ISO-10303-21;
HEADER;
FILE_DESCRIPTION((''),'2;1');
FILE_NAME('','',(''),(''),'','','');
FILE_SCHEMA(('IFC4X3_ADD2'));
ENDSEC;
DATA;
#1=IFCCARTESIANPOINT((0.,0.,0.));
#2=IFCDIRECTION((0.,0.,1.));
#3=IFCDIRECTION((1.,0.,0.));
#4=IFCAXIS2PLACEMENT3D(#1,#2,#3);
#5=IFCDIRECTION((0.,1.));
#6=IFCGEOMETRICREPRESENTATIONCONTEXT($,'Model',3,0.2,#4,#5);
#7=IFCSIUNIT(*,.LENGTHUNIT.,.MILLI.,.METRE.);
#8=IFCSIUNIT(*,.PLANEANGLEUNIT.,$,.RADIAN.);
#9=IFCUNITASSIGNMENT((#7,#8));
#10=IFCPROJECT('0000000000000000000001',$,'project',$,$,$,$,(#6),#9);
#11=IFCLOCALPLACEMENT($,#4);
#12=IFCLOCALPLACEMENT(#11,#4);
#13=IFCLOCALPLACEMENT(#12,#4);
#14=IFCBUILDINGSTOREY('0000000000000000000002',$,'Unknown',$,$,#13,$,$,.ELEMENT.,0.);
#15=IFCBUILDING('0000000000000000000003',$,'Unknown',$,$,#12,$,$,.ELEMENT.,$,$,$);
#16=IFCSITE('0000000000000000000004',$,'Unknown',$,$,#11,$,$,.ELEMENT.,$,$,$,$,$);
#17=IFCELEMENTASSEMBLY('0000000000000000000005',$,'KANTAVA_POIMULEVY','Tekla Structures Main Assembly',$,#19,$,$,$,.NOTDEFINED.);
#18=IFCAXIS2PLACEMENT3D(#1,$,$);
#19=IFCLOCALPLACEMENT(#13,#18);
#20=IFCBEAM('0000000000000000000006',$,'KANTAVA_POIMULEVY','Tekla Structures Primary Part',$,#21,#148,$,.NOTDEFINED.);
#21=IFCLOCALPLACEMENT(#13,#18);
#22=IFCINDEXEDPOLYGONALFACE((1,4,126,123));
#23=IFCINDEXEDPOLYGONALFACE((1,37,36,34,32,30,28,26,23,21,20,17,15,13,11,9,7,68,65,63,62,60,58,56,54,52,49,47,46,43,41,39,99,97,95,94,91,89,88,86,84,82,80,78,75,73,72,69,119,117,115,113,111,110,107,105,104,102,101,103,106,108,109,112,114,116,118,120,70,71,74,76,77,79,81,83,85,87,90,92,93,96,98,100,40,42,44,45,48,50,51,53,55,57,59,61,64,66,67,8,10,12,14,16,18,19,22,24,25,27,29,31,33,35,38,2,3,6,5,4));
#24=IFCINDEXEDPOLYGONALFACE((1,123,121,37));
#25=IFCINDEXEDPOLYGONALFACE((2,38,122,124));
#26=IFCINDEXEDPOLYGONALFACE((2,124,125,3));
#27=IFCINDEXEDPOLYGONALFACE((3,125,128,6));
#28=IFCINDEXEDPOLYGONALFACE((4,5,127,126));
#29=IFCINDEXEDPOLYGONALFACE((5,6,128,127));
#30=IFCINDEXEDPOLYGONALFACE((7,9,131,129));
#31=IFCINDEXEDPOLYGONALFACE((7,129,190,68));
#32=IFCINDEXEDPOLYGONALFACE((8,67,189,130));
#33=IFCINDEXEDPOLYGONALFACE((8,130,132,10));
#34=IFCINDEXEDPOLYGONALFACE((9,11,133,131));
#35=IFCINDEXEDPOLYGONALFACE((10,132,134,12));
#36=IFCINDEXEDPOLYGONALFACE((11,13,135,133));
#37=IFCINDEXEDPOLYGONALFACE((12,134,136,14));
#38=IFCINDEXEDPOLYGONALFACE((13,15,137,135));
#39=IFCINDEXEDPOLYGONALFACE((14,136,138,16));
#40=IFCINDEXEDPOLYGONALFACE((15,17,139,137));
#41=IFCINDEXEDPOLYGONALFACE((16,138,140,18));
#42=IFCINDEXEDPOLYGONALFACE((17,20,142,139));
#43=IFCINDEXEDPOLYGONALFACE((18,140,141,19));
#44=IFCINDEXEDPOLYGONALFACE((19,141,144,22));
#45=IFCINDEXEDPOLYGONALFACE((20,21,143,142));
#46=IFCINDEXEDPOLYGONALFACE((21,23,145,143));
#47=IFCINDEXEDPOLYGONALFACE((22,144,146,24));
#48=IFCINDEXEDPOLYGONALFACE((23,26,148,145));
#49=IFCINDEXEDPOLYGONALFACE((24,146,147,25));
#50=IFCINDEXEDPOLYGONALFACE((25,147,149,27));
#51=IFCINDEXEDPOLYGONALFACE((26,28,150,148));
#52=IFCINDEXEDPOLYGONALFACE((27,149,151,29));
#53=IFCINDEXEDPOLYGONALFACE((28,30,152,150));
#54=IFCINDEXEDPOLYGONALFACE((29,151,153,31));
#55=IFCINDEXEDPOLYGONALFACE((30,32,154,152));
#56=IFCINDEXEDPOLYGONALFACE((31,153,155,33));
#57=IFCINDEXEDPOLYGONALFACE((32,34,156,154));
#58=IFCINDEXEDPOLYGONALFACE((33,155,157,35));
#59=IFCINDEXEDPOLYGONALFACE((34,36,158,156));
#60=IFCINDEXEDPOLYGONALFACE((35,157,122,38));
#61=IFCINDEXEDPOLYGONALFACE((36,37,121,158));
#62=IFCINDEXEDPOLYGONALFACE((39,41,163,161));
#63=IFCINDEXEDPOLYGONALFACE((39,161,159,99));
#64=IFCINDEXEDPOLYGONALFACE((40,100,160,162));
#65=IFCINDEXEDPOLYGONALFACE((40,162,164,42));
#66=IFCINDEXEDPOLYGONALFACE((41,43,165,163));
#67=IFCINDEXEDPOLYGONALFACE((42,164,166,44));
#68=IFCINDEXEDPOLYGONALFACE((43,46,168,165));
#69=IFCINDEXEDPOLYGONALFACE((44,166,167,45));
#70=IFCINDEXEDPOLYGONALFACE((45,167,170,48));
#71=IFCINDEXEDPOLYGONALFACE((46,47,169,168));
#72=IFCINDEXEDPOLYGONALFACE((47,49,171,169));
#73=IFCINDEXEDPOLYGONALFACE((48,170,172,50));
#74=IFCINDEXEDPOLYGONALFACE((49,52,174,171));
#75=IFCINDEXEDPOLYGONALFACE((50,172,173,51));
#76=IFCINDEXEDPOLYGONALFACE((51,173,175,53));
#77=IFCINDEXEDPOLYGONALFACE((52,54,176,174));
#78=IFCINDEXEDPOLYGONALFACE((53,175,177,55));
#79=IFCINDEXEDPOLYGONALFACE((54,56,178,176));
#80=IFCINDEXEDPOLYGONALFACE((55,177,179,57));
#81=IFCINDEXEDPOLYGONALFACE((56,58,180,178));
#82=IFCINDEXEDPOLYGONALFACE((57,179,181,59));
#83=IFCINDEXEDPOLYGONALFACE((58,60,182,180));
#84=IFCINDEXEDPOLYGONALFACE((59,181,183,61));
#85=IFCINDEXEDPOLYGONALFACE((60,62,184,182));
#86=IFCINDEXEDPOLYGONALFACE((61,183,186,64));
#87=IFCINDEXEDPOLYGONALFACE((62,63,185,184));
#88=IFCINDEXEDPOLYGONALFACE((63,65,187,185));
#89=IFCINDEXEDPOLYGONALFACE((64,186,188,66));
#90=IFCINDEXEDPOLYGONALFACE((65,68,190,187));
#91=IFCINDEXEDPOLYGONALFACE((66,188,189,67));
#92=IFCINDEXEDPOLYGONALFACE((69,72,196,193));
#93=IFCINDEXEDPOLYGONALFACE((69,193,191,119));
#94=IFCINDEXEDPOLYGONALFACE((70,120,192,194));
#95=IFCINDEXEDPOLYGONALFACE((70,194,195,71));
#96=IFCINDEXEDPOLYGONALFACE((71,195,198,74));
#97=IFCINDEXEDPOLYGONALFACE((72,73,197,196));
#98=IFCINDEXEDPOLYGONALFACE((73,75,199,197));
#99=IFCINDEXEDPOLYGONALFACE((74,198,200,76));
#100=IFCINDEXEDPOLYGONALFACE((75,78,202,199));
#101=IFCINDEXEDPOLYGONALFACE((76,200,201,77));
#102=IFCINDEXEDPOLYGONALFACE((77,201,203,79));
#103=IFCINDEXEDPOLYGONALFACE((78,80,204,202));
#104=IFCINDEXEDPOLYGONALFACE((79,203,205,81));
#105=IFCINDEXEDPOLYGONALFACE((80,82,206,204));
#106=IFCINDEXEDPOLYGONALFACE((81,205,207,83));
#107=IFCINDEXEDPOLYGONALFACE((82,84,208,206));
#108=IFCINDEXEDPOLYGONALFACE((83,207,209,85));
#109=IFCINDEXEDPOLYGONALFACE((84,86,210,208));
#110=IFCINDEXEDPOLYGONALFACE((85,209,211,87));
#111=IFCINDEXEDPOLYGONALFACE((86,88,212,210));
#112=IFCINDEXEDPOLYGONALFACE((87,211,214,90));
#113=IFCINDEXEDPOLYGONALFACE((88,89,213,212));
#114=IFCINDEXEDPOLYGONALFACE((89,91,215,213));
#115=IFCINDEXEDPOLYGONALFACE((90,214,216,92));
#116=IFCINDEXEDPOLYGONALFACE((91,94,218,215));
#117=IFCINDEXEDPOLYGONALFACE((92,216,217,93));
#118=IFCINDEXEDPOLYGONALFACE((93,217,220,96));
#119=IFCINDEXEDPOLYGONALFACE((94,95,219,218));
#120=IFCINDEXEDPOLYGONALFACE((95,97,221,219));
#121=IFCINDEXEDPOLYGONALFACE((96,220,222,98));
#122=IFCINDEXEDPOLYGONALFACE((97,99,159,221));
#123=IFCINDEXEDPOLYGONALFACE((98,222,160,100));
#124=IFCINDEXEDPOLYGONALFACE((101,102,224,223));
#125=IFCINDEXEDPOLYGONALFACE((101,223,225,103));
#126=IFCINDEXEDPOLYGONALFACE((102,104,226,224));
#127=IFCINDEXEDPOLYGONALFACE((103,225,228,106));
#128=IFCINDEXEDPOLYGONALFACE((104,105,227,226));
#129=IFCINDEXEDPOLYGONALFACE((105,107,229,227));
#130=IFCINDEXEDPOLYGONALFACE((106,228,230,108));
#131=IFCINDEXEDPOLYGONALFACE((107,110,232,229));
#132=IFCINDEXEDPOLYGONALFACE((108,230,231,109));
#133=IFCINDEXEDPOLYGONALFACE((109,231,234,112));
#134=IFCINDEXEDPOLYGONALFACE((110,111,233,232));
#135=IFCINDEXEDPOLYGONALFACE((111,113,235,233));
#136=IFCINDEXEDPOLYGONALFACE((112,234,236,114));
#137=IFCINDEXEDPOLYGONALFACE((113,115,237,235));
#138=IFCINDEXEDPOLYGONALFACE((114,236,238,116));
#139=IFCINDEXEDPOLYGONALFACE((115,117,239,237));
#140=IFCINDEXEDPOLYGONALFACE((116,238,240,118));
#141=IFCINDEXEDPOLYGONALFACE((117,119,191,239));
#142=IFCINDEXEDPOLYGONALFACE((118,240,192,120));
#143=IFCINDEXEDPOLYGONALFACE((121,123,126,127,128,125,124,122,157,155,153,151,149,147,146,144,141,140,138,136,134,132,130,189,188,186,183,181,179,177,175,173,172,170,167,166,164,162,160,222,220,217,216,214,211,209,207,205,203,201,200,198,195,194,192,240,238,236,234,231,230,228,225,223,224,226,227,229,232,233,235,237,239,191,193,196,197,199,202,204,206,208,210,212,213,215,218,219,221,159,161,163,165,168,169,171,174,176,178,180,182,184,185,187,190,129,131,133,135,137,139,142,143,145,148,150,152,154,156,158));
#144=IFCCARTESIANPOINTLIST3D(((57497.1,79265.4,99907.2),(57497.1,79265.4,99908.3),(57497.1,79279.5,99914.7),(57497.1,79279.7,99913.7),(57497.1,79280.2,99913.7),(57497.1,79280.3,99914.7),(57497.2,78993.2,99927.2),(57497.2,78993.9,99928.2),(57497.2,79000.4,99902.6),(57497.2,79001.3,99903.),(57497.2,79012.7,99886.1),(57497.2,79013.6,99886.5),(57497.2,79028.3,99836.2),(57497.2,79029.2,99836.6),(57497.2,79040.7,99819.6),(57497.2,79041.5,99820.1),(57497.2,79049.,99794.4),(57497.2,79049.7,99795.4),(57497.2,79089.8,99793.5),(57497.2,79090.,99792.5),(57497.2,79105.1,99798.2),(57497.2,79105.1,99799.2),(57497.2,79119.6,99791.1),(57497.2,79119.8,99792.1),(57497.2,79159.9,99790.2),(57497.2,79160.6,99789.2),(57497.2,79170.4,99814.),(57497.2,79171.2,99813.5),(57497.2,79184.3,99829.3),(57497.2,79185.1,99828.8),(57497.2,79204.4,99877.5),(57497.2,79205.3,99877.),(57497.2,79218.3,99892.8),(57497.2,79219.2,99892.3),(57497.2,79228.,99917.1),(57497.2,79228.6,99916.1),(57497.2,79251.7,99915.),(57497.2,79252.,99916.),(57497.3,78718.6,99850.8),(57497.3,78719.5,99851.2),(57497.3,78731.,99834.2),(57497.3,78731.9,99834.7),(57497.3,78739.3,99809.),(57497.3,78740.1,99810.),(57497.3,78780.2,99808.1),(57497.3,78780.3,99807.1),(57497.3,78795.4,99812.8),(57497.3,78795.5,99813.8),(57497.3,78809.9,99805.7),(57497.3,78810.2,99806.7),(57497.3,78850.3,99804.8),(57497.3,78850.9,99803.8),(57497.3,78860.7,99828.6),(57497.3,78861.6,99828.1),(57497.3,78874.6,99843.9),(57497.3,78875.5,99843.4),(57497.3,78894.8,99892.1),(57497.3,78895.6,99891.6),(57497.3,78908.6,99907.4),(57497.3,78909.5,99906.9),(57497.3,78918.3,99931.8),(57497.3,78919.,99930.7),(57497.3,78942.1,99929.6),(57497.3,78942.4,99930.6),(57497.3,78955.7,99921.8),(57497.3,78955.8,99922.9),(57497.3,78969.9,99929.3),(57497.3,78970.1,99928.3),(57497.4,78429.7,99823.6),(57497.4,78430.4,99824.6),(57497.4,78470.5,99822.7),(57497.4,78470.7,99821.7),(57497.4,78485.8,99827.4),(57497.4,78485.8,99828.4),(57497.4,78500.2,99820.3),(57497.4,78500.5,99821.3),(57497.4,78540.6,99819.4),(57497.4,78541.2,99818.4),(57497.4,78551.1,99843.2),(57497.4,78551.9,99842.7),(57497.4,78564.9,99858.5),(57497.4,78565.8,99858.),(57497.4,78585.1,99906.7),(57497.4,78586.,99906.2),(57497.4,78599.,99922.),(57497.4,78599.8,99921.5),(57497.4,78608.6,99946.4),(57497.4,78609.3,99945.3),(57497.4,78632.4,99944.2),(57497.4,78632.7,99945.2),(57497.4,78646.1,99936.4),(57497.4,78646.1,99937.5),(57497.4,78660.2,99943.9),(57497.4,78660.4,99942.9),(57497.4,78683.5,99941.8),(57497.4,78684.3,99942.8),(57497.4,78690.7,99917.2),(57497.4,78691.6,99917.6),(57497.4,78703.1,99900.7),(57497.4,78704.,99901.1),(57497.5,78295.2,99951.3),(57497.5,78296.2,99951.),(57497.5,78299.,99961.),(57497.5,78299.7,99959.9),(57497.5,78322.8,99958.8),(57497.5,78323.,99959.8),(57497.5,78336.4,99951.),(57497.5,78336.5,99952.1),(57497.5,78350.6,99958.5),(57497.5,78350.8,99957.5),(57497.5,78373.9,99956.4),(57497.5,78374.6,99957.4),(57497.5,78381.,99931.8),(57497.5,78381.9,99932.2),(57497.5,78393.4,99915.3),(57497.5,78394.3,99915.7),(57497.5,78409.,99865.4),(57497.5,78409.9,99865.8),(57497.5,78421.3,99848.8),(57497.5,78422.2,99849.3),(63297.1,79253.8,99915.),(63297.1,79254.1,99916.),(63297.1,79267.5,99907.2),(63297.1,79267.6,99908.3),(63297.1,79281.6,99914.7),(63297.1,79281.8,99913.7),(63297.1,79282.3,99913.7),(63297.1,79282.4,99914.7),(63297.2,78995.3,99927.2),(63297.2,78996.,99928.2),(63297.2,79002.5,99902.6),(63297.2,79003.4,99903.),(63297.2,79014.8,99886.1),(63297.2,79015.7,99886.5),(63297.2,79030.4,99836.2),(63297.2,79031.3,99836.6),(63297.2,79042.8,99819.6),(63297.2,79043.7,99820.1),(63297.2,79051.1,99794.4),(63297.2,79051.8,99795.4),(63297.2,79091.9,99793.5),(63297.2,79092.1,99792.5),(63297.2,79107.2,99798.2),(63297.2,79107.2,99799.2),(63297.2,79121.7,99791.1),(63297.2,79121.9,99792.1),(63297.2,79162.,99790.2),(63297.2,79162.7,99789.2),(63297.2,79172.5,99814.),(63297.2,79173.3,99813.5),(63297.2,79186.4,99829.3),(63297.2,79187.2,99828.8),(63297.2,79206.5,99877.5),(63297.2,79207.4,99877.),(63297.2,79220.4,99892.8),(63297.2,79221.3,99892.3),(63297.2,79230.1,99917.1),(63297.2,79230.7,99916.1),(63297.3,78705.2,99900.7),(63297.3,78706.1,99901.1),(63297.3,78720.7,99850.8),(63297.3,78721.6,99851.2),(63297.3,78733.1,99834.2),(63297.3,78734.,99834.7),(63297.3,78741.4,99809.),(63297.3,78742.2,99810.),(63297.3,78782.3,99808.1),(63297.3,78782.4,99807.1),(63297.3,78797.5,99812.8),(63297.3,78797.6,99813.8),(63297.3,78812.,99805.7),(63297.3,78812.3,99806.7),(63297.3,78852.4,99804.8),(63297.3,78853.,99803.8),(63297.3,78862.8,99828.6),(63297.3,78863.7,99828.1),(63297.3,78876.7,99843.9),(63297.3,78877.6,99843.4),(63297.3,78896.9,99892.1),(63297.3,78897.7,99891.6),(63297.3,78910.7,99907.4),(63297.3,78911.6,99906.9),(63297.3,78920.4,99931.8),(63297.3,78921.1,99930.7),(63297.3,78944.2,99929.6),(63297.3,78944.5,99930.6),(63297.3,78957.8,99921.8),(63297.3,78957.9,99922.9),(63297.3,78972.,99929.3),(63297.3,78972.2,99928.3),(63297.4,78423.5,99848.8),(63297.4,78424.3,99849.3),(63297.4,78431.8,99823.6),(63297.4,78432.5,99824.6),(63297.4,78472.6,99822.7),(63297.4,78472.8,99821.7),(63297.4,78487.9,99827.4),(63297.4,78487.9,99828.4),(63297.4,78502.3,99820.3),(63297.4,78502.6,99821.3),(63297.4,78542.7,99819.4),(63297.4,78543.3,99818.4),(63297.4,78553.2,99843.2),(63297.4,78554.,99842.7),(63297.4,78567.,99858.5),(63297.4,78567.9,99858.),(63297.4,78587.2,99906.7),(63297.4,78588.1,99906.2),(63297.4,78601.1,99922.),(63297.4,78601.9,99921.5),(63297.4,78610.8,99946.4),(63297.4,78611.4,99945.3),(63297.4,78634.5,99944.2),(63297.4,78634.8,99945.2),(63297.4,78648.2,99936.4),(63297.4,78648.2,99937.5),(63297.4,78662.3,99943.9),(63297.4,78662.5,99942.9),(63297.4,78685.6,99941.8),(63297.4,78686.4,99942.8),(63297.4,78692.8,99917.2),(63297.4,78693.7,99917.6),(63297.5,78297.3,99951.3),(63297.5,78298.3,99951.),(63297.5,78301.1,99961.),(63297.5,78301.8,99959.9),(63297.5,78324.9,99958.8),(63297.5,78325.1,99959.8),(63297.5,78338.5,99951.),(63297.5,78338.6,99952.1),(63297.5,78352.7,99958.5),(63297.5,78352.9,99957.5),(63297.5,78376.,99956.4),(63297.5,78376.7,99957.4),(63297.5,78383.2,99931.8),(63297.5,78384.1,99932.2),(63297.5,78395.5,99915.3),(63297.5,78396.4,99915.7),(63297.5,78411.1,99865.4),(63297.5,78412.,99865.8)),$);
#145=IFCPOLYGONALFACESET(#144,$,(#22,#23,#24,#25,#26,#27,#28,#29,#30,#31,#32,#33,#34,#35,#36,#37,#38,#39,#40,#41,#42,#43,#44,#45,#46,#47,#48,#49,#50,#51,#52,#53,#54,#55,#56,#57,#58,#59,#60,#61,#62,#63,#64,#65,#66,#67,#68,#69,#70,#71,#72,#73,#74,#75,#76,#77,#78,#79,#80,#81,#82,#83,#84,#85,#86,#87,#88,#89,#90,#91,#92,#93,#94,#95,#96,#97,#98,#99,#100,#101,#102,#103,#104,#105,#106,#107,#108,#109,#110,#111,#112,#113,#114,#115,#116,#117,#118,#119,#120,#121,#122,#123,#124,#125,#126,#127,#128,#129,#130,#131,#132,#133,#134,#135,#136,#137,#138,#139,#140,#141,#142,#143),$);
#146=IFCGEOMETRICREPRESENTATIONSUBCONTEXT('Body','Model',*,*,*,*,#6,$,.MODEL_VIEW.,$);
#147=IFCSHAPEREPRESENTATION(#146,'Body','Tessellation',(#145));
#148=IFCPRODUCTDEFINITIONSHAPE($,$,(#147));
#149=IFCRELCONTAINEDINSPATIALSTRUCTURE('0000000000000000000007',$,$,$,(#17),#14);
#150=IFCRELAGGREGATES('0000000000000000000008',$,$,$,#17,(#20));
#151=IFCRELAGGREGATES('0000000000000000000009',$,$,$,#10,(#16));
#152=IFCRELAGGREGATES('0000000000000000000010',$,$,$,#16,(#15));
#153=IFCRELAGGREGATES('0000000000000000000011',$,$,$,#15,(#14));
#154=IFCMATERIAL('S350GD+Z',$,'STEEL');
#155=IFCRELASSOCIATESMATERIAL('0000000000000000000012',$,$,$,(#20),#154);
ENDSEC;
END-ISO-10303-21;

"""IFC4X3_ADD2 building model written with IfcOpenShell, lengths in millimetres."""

from ifc_helpers import new_model, si_unit, direction, frame, origin_with_axes, place, context, subcontext, project, spatial, line, indexed_curve, outline, extrude, material, element, aggregate, save


model = new_model("IFC4X3_ADD2")

# Units and contexts
model_context = context("Model", 3, precision=0.2, world=origin_with_axes(), true_north=direction((0.0, 1.0)))
body_context = subcontext(model_context, "Body", "Model", "MODEL_VIEW")
ifc_project = project(units=[si_unit("LENGTHUNIT", "METRE", prefix="MILLI"), si_unit("PLANEANGLEUNIT", "RADIAN")], contexts=[model_context])

# Site, building, storey
site_placement = place(None, origin_with_axes())
site = spatial("IfcSite", under=ifc_project, at=site_placement, Name="Unknown", CompositionType="ELEMENT")
building_placement = place(site_placement, origin_with_axes())
building = spatial("IfcBuilding", under=site, at=building_placement, Name="Unknown", CompositionType="ELEMENT")
storey_placement = place(building_placement, origin_with_axes())
storey = spatial("IfcBuildingStorey", under=building, at=storey_placement, Name="Unknown", CompositionType="ELEMENT", Elevation=0.0)

# Element assembly, beam
ifc_material_1 = material(Name="S350GD+Z", Category="STEEL")
assembly_1_placement = place(storey_placement, frame((63297.3, 78800.3, 99871.8), z_axis=(-0.000363, 0.99889, -0.047106), x_axis=(-1.0, -0.000363, 0.0)))
assembly_1 = element("IfcElementAssembly", 1, at=assembly_1_placement, inside=storey, Name="KANTAVA_POIMULEVY", Description="Tekla Structures Main Assembly", PredefinedType="NOTDEFINED")
beam_1_placement = place(assembly_1_placement, origin_with_axes())
beam_1 = element("IfcBeam", 2, at=beam_1_placement, material=ifc_material_1, Name="KANTAVA_POIMULEVY", Description="Tekla Structures Primary Part", PredefinedType="NOTDEFINED", context=body_context, shape_type="SolidModel", body=[
    extrude(outline(indexed_curve([(479.5, 65.5), (478.8, 65.5), (465.0, 58.5), (451.2, 65.5), (427.1, 65.5), (418.6, 40.7), (405.5, 24.8), (387.6, -24.3), (374.5, -40.2), (365.1, -64.5), (325.0, -64.5), (310.0, -58.1), (295.0, -64.5), (254.8, -64.5), (245.5, -40.2), (232.4, -24.3), (214.5, 24.8), (201.4, 40.7), (192.9, 65.5), (168.8, 65.5), (155.0, 58.5), (141.2, 65.5), (117.1, 65.5), (108.6, 40.7), (95.5, 24.8), (77.6, -24.3), (64.5, -40.2), (55.1, -64.5), (15.0, -64.5), (0.0, -58.1), (-15.0, -64.5), (-55.2, -64.5), (-64.5, -40.2), (-77.6, -24.3), (-95.5, 24.8), (-108.6, 40.7), (-117.2, 65.5), (-141.2, 65.5), (-155.0, 58.5), (-168.8, 65.5), (-192.9, 65.5), (-201.4, 40.7), (-214.5, 24.8), (-232.4, -24.3), (-245.5, -40.2), (-254.9, -64.5), (-295.0, -64.5), (-310.0, -58.1), (-325.0, -64.5), (-365.2, -64.5), (-374.5, -40.2), (-387.6, -24.3), (-405.5, 24.8), (-418.6, 40.7), (-427.1, 65.5), (-451.2, 65.5), (-465.0, 58.5), (-478.8, 65.5), (-502.9, 65.5), (-506.2, 55.7), (-505.2, 55.4), (-502.1, 64.5), (-479.0, 64.5), (-465.0, 57.3), (-451.0, 64.5), (-427.9, 64.5), (-419.5, 40.2), (-406.4, 24.3), (-388.5, -24.8), (-375.4, -40.7), (-365.9, -65.5), (-324.8, -65.5), (-310.0, -59.1), (-295.2, -65.5), (-254.2, -65.5), (-244.6, -40.7), (-231.5, -24.8), (-213.6, 24.3), (-200.5, 40.2), (-192.1, 64.5), (-169.0, 64.5), (-155.0, 57.3), (-141.0, 64.5), (-117.9, 64.5), (-109.5, 40.2), (-96.4, 24.3), (-78.5, -24.8), (-65.4, -40.7), (-55.9, -65.5), (-14.8, -65.5), (0.0, -59.1), (14.8, -65.5), (55.8, -65.5), (65.4, -40.7), (78.5, -24.8), (96.4, 24.3), (109.5, 40.2), (117.8, 64.5), (141.0, 64.5), (155.0, 57.3), (169.0, 64.5), (192.1, 64.5), (200.5, 40.2), (213.6, 24.3), (231.5, -24.8), (244.6, -40.7), (254.1, -65.5), (295.2, -65.5), (310.0, -59.1), (324.8, -65.5), (365.8, -65.5), (375.4, -40.7), (388.5, -24.8), (406.4, 24.3), (419.5, 40.2), (427.9, 64.5), (451.0, 64.5), (465.0, 57.3), (479.0, 64.5), (479.5, 64.5)], segments=[line(1, 2, 3, 4, 5, 6, 7, 8, 9, 10, 11, 12, 13, 14, 15, 16, 17, 18, 19, 20, 21, 22, 23, 24, 25, 26, 27, 28, 29, 30, 31, 32, 33, 34, 35, 36, 37, 38, 39, 40, 41, 42, 43, 44, 45, 46, 47, 48, 49, 50, 51, 52, 53, 54, 55, 56, 57, 58, 59, 60, 61, 62, 63, 64, 65, 66, 67, 68, 69, 70, 71, 72, 73, 74, 75, 76, 77, 78, 79, 80, 81, 82, 83, 84, 85, 86, 87, 88, 89, 90, 91, 92, 93, 94, 95, 96, 97, 98, 99, 100, 101, 102, 103, 104, 105, 106, 107, 108, 109, 110, 111, 112, 113, 114, 115, 116, 117, 118, 119, 120, 1)])), frame((0.0, 0.0, 0.0), z_axis=(-1.0, 0.0, 0.0), x_axis=(0.0, 0.0, 1.0)), (0.0, 0.0, -1.0), 5800.0),
])
aggregate(assembly_1, [beam_1])

save(model, "model.ifc")
